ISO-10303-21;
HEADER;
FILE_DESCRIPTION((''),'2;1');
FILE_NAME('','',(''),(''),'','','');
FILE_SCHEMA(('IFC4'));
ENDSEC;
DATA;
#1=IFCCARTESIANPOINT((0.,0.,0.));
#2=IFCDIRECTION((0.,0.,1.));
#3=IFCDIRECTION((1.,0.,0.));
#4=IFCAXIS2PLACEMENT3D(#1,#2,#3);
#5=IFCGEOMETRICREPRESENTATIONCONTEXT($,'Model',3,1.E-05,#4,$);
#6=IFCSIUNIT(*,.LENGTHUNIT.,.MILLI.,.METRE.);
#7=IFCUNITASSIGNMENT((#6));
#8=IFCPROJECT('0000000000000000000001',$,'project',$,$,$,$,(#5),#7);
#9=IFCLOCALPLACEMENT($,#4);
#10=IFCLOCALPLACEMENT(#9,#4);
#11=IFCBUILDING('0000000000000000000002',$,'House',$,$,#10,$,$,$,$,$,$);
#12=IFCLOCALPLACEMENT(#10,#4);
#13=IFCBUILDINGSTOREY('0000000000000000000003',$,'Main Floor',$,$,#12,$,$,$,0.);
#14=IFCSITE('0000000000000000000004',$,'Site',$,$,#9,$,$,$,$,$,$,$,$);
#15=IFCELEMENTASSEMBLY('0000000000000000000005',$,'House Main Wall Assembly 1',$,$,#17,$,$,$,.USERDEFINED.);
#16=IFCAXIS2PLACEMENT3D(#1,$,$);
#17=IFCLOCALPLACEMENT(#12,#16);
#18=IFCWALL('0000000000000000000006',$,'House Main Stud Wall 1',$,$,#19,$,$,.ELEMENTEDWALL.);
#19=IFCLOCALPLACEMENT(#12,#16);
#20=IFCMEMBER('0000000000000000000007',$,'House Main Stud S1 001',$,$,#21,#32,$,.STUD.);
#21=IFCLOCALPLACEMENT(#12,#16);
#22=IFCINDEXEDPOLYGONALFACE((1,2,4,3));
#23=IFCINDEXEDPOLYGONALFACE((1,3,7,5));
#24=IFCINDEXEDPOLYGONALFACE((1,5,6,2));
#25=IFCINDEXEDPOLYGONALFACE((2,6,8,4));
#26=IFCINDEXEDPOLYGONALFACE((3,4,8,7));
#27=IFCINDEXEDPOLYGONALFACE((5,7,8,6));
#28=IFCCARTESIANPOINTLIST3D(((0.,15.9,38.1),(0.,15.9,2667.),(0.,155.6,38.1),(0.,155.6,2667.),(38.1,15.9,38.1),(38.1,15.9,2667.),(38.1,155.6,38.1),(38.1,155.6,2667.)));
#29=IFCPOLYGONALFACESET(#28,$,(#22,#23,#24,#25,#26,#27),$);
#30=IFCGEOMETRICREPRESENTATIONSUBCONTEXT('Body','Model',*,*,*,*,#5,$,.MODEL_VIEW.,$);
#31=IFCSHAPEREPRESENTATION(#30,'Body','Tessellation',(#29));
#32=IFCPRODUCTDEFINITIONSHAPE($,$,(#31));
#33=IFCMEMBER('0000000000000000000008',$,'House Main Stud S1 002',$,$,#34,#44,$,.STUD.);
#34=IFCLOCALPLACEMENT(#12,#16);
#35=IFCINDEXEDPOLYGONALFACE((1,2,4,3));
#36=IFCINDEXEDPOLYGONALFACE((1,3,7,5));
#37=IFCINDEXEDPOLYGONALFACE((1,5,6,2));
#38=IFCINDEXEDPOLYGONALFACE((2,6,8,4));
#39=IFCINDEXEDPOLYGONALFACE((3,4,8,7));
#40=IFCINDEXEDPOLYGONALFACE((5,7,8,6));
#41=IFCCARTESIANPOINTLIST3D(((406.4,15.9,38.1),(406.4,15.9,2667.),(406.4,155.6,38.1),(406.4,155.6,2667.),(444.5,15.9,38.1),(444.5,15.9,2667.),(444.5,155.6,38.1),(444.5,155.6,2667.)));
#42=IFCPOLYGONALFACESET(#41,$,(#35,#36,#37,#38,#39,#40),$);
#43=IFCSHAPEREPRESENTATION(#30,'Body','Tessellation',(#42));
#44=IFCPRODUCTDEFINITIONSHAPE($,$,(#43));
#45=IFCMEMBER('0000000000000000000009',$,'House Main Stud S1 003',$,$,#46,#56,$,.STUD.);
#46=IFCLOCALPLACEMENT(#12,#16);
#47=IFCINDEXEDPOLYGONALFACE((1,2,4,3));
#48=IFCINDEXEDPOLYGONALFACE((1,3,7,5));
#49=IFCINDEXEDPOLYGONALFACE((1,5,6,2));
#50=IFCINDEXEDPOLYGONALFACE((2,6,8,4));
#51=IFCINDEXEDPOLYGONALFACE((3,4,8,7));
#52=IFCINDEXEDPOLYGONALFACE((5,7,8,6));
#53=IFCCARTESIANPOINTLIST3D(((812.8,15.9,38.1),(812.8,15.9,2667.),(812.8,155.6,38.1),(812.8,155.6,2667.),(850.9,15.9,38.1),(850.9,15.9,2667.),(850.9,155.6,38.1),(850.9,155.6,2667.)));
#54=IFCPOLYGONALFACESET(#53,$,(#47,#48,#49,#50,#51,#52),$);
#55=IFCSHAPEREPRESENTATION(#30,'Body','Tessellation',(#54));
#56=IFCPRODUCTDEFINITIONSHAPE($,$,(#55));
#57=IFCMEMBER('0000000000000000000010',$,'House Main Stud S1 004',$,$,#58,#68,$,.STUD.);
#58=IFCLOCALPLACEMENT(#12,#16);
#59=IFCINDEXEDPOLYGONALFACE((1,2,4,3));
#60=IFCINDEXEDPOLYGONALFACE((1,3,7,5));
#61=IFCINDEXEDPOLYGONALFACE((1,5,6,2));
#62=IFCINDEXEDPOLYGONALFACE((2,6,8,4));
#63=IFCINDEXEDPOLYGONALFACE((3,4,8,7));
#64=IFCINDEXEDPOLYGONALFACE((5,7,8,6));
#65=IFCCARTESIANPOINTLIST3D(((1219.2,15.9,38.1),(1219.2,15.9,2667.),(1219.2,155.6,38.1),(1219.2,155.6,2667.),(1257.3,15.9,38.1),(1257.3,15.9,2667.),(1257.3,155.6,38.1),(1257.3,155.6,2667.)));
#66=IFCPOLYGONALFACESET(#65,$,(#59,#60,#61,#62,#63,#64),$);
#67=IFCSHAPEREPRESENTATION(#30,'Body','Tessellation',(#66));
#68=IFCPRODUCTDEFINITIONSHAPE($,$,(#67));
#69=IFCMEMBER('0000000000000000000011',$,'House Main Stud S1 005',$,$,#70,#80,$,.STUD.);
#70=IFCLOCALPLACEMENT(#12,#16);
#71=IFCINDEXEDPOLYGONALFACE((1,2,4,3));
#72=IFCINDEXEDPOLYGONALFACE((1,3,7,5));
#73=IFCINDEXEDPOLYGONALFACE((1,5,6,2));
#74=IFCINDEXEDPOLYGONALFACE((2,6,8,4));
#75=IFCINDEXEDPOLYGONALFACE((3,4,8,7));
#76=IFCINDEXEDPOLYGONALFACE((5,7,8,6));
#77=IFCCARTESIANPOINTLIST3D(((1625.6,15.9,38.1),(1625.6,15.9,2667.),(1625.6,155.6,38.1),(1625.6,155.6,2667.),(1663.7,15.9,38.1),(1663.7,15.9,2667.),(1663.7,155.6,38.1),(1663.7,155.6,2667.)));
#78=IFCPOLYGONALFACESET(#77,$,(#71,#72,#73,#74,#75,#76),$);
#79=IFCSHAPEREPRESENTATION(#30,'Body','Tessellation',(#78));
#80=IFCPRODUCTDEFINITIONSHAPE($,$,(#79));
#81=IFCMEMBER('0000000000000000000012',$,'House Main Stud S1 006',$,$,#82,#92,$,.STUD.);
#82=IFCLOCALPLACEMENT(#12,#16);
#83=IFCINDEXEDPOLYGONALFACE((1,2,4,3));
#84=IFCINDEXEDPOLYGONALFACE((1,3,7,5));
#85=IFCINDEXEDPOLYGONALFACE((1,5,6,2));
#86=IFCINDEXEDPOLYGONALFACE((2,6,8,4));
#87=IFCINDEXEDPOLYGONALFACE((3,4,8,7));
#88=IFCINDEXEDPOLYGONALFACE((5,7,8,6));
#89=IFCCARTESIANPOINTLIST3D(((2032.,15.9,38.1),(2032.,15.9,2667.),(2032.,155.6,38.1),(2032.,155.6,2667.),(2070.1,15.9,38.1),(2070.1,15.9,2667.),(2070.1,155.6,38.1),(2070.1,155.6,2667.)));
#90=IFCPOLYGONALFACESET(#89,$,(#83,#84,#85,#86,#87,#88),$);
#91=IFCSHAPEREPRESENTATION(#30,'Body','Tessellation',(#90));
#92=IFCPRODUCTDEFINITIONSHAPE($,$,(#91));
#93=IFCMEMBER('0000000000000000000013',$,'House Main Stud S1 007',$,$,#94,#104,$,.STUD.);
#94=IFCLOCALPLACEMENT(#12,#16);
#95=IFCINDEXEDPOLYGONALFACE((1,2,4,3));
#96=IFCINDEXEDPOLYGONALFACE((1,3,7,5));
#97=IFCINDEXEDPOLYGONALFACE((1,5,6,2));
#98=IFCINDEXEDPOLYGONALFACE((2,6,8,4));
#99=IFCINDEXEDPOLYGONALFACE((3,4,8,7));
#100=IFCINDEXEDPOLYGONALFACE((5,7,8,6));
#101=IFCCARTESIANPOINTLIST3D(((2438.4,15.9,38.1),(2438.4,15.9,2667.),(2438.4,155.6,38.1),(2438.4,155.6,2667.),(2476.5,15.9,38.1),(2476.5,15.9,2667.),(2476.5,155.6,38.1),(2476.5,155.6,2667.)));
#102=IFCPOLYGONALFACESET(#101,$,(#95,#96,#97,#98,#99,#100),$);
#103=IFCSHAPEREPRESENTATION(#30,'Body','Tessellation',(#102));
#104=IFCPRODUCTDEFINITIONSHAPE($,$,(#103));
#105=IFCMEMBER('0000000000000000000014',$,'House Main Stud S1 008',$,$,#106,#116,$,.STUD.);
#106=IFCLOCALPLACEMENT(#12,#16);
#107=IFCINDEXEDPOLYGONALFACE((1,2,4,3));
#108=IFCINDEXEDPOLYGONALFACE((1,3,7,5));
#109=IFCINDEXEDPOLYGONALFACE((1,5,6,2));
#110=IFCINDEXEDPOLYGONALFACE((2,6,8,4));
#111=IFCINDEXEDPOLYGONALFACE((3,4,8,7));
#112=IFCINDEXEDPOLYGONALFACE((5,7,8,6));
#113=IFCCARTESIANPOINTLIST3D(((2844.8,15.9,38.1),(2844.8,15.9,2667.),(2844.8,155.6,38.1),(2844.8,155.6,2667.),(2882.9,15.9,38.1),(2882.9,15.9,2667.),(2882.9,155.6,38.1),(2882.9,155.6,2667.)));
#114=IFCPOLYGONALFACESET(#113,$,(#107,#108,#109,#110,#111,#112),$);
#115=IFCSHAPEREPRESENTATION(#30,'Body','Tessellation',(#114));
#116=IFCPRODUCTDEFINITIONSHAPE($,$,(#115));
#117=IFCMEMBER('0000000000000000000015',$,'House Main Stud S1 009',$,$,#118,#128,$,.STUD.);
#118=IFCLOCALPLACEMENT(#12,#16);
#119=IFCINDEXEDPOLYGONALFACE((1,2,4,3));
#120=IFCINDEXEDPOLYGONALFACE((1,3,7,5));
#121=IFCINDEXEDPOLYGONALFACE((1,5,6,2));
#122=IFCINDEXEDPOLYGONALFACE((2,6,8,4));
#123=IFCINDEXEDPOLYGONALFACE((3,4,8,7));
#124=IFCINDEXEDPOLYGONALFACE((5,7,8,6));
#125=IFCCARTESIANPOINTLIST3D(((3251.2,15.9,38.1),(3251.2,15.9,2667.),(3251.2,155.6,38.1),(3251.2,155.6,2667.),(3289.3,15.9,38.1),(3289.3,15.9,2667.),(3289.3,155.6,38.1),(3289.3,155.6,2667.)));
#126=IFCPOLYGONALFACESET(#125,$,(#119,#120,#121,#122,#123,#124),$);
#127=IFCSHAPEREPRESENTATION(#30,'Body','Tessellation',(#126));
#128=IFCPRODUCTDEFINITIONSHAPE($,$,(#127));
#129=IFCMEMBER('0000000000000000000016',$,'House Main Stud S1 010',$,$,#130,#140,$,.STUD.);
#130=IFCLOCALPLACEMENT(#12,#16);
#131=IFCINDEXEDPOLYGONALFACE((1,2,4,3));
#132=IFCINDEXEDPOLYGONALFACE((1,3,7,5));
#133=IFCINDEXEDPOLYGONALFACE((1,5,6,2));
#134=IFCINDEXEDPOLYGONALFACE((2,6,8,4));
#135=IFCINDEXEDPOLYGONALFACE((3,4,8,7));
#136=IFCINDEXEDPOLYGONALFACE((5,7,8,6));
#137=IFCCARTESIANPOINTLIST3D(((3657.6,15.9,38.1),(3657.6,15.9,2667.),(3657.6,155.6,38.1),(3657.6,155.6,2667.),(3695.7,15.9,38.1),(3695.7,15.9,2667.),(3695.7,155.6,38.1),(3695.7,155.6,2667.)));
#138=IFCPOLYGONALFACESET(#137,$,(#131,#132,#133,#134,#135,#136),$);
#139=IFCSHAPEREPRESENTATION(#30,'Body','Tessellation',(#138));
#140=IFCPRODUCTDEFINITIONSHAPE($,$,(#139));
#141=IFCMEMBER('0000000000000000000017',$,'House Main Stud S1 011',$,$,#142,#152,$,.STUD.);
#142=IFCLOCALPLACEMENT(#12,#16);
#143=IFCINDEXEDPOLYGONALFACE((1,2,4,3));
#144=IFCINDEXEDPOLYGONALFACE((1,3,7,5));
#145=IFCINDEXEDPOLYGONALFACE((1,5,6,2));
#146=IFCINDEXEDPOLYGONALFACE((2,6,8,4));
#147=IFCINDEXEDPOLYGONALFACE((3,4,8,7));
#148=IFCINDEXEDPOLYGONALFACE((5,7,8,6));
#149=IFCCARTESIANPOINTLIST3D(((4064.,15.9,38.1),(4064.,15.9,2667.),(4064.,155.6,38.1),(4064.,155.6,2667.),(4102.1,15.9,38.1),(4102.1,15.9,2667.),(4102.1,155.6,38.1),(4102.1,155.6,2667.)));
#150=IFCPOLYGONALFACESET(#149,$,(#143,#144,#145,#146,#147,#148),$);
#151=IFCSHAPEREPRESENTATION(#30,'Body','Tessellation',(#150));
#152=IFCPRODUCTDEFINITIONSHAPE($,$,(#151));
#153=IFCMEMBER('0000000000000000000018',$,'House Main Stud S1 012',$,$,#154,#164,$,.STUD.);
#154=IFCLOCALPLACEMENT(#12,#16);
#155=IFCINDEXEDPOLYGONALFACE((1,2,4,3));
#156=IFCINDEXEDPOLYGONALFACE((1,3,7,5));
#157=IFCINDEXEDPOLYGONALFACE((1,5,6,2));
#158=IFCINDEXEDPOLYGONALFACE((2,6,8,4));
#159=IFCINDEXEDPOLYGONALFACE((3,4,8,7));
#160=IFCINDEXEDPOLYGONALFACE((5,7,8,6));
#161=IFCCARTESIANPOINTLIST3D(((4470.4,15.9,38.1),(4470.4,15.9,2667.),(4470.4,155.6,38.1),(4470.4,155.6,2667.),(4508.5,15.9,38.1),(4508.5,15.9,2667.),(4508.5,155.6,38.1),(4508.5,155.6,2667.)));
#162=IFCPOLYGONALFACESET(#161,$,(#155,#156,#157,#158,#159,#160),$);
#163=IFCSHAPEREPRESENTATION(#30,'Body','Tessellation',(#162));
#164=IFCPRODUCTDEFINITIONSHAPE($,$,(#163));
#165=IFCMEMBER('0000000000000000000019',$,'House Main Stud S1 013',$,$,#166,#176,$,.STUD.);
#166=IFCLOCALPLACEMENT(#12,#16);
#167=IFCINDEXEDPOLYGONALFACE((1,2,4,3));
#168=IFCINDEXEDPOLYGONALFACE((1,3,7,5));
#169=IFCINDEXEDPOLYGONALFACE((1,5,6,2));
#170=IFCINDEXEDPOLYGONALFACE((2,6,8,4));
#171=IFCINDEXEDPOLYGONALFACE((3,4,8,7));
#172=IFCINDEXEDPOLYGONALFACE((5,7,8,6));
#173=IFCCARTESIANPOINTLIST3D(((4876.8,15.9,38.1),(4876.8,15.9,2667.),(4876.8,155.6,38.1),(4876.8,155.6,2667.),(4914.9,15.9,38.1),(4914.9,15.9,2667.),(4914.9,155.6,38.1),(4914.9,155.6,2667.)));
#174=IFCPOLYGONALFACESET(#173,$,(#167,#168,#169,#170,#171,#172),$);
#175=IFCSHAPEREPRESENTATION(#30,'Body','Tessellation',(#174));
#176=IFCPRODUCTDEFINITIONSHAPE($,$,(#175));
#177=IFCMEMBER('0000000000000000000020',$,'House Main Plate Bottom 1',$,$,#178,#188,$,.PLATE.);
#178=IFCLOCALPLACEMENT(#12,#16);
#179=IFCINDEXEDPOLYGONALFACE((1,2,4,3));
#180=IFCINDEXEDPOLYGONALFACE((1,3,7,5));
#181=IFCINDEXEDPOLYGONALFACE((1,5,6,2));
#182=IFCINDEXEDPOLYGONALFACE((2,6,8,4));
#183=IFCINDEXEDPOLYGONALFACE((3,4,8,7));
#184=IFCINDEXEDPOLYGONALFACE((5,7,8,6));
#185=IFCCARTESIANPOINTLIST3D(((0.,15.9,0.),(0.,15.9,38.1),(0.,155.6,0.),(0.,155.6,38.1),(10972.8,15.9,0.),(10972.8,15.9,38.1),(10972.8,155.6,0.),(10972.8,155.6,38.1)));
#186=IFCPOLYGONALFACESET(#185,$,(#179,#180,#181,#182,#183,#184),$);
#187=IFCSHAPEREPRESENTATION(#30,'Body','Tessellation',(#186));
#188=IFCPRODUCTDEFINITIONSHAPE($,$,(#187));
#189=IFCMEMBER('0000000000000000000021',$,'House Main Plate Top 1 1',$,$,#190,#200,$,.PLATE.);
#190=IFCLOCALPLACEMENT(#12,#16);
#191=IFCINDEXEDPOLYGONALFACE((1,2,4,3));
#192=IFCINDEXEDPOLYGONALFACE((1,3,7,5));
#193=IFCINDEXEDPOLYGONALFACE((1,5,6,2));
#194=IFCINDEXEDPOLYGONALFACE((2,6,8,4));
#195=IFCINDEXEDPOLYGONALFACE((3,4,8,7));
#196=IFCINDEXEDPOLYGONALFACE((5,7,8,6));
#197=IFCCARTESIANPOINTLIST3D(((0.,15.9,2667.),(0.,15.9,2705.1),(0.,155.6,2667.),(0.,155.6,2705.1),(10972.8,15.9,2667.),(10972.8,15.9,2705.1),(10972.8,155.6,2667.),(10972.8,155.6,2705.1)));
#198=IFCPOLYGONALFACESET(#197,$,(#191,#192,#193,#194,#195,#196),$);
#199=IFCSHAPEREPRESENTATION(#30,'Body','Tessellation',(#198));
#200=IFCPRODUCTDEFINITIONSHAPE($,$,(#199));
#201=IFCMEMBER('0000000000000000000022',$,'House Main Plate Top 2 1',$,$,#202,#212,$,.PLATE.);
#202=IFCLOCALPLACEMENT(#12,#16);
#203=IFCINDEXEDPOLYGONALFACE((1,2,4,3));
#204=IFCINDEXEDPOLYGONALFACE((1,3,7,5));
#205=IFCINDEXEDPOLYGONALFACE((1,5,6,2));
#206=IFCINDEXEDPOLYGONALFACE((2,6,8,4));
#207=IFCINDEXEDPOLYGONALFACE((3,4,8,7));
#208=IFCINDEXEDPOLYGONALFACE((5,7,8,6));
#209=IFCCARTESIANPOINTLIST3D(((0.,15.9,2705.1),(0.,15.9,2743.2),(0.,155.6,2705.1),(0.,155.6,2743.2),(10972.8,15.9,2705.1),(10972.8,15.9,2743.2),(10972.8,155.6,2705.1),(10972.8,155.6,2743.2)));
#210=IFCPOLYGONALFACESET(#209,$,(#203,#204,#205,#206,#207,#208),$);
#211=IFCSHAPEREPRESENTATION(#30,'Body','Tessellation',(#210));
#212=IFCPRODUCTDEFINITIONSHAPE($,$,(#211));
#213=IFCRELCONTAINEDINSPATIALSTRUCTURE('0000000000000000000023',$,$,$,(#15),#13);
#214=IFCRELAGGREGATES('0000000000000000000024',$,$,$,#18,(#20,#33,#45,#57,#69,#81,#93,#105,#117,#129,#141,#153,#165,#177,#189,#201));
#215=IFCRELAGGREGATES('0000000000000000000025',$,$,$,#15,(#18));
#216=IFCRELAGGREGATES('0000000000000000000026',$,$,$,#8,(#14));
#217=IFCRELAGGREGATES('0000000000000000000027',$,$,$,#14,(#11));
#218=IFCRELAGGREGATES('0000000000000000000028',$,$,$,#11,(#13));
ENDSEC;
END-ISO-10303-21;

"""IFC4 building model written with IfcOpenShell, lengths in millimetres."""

from ifc_helpers import new_model, si_unit, frame, origin_with_axes, origin_2d, place, context, subcontext, project, spatial, rectangle, extrude, element, aggregate, save


model = new_model("IFC4")

# Units and contexts
model_context = context("Model", 3, precision=1e-05, world=origin_with_axes())
body_context = subcontext(model_context, "Body", "Model", "MODEL_VIEW")
ifc_project = project(units=[si_unit("LENGTHUNIT", "METRE", prefix="MILLI")], contexts=[model_context])

# Site, building, storey
site_placement = place(None, origin_with_axes())
site = spatial("IfcSite", under=ifc_project, at=site_placement, Name="Site")
building_placement = place(site_placement, origin_with_axes())
building = spatial("IfcBuilding", under=site, at=building_placement, Name="House")
storey_placement = place(building_placement, origin_with_axes())
storey = spatial("IfcBuildingStorey", under=building, at=storey_placement, Name="Main Floor", Elevation=0.0)

# Element assembly, wall, members
assembly_1_placement = place(storey_placement, origin_with_axes())
assembly_1 = element("IfcElementAssembly", 1, at=assembly_1_placement, inside=storey, Name="House Main Wall Assembly 1", PredefinedType="USERDEFINED")
wall_1_placement = place(assembly_1_placement, origin_with_axes())
wall_1 = element("IfcWall", 2, at=wall_1_placement, Name="House Main Stud Wall 1", PredefinedType="ELEMENTEDWALL")
member_1_placement = place(wall_1_placement, frame((19.1, 85.7, 38.1), z_axis=(0.0, 0.0, 1.0), x_axis=(1.0, 0.0, 0.0)))
member_1 = element("IfcMember", 3, at=member_1_placement, Name="House Main Stud S1 001", PredefinedType="STUD", context=body_context, shape_type="SweptSolid", body=[
    extrude(rectangle(XDim=38.1, YDim=139.7, at=origin_2d()), origin_with_axes(), (0.0, 0.0, 1.0), 2628.9),
])
member_2_placement = place(wall_1_placement, frame((425.4, 85.7, 38.1), z_axis=(0.0, 0.0, 1.0), x_axis=(1.0, 0.0, 0.0)))
member_2 = element("IfcMember", 4, at=member_2_placement, Name="House Main Stud S1 002", PredefinedType="STUD", context=body_context, shape_type="SweptSolid", body=[
    extrude(rectangle(XDim=38.1, YDim=139.7, at=origin_2d()), origin_with_axes(), (0.0, 0.0, 1.0), 2628.9),
])
member_3_placement = place(wall_1_placement, frame((831.9, 85.7, 38.1), z_axis=(0.0, 0.0, 1.0), x_axis=(1.0, 0.0, 0.0)))
member_3 = element("IfcMember", 5, at=member_3_placement, Name="House Main Stud S1 003", PredefinedType="STUD", context=body_context, shape_type="SweptSolid", body=[
    extrude(rectangle(XDim=38.1, YDim=139.7, at=origin_2d()), origin_with_axes(), (0.0, 0.0, 1.0), 2628.9),
])
member_4_placement = place(wall_1_placement, frame((1238.2, 85.7, 38.1), z_axis=(0.0, 0.0, 1.0), x_axis=(1.0, 0.0, 0.0)))
member_4 = element("IfcMember", 6, at=member_4_placement, Name="House Main Stud S1 004", PredefinedType="STUD", context=body_context, shape_type="SweptSolid", body=[
    extrude(rectangle(XDim=38.1, YDim=139.7, at=origin_2d()), origin_with_axes(), (0.0, 0.0, 1.0), 2628.9),
])
member_5_placement = place(wall_1_placement, frame((1644.7, 85.7, 38.1), z_axis=(0.0, 0.0, 1.0), x_axis=(1.0, 0.0, 0.0)))
member_5 = element("IfcMember", 7, at=member_5_placement, Name="House Main Stud S1 005", PredefinedType="STUD", context=body_context, shape_type="SweptSolid", body=[
    extrude(rectangle(XDim=38.1, YDim=139.7, at=origin_2d()), origin_with_axes(), (0.0, 0.0, 1.0), 2628.9),
])
member_6_placement = place(wall_1_placement, frame((2051.1, 85.7, 38.1), z_axis=(0.0, 0.0, 1.0), x_axis=(1.0, 0.0, 0.0)))
member_6 = element("IfcMember", 8, at=member_6_placement, Name="House Main Stud S1 006", PredefinedType="STUD", context=body_context, shape_type="SweptSolid", body=[
    extrude(rectangle(XDim=38.1, YDim=139.7, at=origin_2d()), origin_with_axes(), (0.0, 0.0, 1.0), 2628.9),
])
member_7_placement = place(wall_1_placement, frame((2457.4, 85.7, 38.1), z_axis=(0.0, 0.0, 1.0), x_axis=(1.0, 0.0, 0.0)))
member_7 = element("IfcMember", 9, at=member_7_placement, Name="House Main Stud S1 007", PredefinedType="STUD", context=body_context, shape_type="SweptSolid", body=[
    extrude(rectangle(XDim=38.1, YDim=139.7, at=origin_2d()), origin_with_axes(), (0.0, 0.0, 1.0), 2628.9),
])
member_8_placement = place(wall_1_placement, frame((2863.8, 85.7, 38.1), z_axis=(0.0, 0.0, 1.0), x_axis=(1.0, 0.0, 0.0)))
member_8 = element("IfcMember", 10, at=member_8_placement, Name="House Main Stud S1 008", PredefinedType="STUD", context=body_context, shape_type="SweptSolid", body=[
    extrude(rectangle(XDim=38.1, YDim=139.7, at=origin_2d()), origin_with_axes(), (0.0, 0.0, 1.0), 2628.9),
])
member_9_placement = place(wall_1_placement, frame((3270.2, 85.7, 38.1), z_axis=(0.0, 0.0, 1.0), x_axis=(1.0, 0.0, 0.0)))
member_9 = element("IfcMember", 11, at=member_9_placement, Name="House Main Stud S1 009", PredefinedType="STUD", context=body_context, shape_type="SweptSolid", body=[
    extrude(rectangle(XDim=38.1, YDim=139.7, at=origin_2d()), origin_with_axes(), (0.0, 0.0, 1.0), 2628.9),
])
member_10_placement = place(wall_1_placement, frame((3676.7, 85.7, 38.1), z_axis=(0.0, 0.0, 1.0), x_axis=(1.0, 0.0, 0.0)))
member_10 = element("IfcMember", 12, at=member_10_placement, Name="House Main Stud S1 010", PredefinedType="STUD", context=body_context, shape_type="SweptSolid", body=[
    extrude(rectangle(XDim=38.1, YDim=139.7, at=origin_2d()), origin_with_axes(), (0.0, 0.0, 1.0), 2628.9),
])
member_11_placement = place(wall_1_placement, frame((4083.1, 85.7, 38.1), z_axis=(0.0, 0.0, 1.0), x_axis=(1.0, 0.0, 0.0)))
member_11 = element("IfcMember", 13, at=member_11_placement, Name="House Main Stud S1 011", PredefinedType="STUD", context=body_context, shape_type="SweptSolid", body=[
    extrude(rectangle(XDim=38.1, YDim=139.7, at=origin_2d()), origin_with_axes(), (0.0, 0.0, 1.0), 2628.9),
])
member_12_placement = place(wall_1_placement, frame((4489.4, 85.7, 38.1), z_axis=(0.0, 0.0, 1.0), x_axis=(1.0, 0.0, 0.0)))
member_12 = element("IfcMember", 14, at=member_12_placement, Name="House Main Stud S1 012", PredefinedType="STUD", context=body_context, shape_type="SweptSolid", body=[
    extrude(rectangle(XDim=38.1, YDim=139.7, at=origin_2d()), origin_with_axes(), (0.0, 0.0, 1.0), 2628.9),
])
member_13_placement = place(wall_1_placement, frame((4895.9, 85.7, 38.1), z_axis=(0.0, 0.0, 1.0), x_axis=(1.0, 0.0, 0.0)))
member_13 = element("IfcMember", 15, at=member_13_placement, Name="House Main Stud S1 013", PredefinedType="STUD", context=body_context, shape_type="SweptSolid", body=[
    extrude(rectangle(XDim=38.1, YDim=139.7, at=origin_2d()), origin_with_axes(), (0.0, 0.0, 1.0), 2628.9),
])
member_14_placement = place(wall_1_placement, frame((0.0, 85.7, 19.1), z_axis=(1.0, 0.0, 0.0), x_axis=(0.0, 0.0, 1.0)))
member_14 = element("IfcMember", 16, at=member_14_placement, Name="House Main Plate Bottom 1", PredefinedType="PLATE", context=body_context, shape_type="SweptSolid", body=[
    extrude(rectangle(XDim=38.1, YDim=139.7, at=origin_2d()), origin_with_axes(), (0.0, 0.0, 1.0), 10972.8),
])
member_15_placement = place(wall_1_placement, frame((0.0, 85.7, 2686.1), z_axis=(1.0, 0.0, 0.0), x_axis=(0.0, 0.0, 1.0)))
member_15 = element("IfcMember", 17, at=member_15_placement, Name="House Main Plate Top 1 1", PredefinedType="PLATE", context=body_context, shape_type="SweptSolid", body=[
    extrude(rectangle(XDim=38.1, YDim=139.7, at=origin_2d()), origin_with_axes(), (0.0, 0.0, 1.0), 10972.8),
])
member_16_placement = place(wall_1_placement, frame((0.0, 85.7, 2724.2), z_axis=(1.0, 0.0, 0.0), x_axis=(0.0, 0.0, 1.0)))
member_16 = element("IfcMember", 18, at=member_16_placement, Name="House Main Plate Top 2 1", PredefinedType="PLATE", context=body_context, shape_type="SweptSolid", body=[
    extrude(rectangle(XDim=38.1, YDim=139.7, at=origin_2d()), origin_with_axes(), (0.0, 0.0, 1.0), 10972.8),
])
aggregate(wall_1, [member_1, member_2, member_3, member_4, member_5, member_6, member_7, member_8, member_9, member_10, member_11, member_12, member_13, member_14, member_15, member_16])

aggregate(assembly_1, [wall_1])

save(model, "model.ifc")
